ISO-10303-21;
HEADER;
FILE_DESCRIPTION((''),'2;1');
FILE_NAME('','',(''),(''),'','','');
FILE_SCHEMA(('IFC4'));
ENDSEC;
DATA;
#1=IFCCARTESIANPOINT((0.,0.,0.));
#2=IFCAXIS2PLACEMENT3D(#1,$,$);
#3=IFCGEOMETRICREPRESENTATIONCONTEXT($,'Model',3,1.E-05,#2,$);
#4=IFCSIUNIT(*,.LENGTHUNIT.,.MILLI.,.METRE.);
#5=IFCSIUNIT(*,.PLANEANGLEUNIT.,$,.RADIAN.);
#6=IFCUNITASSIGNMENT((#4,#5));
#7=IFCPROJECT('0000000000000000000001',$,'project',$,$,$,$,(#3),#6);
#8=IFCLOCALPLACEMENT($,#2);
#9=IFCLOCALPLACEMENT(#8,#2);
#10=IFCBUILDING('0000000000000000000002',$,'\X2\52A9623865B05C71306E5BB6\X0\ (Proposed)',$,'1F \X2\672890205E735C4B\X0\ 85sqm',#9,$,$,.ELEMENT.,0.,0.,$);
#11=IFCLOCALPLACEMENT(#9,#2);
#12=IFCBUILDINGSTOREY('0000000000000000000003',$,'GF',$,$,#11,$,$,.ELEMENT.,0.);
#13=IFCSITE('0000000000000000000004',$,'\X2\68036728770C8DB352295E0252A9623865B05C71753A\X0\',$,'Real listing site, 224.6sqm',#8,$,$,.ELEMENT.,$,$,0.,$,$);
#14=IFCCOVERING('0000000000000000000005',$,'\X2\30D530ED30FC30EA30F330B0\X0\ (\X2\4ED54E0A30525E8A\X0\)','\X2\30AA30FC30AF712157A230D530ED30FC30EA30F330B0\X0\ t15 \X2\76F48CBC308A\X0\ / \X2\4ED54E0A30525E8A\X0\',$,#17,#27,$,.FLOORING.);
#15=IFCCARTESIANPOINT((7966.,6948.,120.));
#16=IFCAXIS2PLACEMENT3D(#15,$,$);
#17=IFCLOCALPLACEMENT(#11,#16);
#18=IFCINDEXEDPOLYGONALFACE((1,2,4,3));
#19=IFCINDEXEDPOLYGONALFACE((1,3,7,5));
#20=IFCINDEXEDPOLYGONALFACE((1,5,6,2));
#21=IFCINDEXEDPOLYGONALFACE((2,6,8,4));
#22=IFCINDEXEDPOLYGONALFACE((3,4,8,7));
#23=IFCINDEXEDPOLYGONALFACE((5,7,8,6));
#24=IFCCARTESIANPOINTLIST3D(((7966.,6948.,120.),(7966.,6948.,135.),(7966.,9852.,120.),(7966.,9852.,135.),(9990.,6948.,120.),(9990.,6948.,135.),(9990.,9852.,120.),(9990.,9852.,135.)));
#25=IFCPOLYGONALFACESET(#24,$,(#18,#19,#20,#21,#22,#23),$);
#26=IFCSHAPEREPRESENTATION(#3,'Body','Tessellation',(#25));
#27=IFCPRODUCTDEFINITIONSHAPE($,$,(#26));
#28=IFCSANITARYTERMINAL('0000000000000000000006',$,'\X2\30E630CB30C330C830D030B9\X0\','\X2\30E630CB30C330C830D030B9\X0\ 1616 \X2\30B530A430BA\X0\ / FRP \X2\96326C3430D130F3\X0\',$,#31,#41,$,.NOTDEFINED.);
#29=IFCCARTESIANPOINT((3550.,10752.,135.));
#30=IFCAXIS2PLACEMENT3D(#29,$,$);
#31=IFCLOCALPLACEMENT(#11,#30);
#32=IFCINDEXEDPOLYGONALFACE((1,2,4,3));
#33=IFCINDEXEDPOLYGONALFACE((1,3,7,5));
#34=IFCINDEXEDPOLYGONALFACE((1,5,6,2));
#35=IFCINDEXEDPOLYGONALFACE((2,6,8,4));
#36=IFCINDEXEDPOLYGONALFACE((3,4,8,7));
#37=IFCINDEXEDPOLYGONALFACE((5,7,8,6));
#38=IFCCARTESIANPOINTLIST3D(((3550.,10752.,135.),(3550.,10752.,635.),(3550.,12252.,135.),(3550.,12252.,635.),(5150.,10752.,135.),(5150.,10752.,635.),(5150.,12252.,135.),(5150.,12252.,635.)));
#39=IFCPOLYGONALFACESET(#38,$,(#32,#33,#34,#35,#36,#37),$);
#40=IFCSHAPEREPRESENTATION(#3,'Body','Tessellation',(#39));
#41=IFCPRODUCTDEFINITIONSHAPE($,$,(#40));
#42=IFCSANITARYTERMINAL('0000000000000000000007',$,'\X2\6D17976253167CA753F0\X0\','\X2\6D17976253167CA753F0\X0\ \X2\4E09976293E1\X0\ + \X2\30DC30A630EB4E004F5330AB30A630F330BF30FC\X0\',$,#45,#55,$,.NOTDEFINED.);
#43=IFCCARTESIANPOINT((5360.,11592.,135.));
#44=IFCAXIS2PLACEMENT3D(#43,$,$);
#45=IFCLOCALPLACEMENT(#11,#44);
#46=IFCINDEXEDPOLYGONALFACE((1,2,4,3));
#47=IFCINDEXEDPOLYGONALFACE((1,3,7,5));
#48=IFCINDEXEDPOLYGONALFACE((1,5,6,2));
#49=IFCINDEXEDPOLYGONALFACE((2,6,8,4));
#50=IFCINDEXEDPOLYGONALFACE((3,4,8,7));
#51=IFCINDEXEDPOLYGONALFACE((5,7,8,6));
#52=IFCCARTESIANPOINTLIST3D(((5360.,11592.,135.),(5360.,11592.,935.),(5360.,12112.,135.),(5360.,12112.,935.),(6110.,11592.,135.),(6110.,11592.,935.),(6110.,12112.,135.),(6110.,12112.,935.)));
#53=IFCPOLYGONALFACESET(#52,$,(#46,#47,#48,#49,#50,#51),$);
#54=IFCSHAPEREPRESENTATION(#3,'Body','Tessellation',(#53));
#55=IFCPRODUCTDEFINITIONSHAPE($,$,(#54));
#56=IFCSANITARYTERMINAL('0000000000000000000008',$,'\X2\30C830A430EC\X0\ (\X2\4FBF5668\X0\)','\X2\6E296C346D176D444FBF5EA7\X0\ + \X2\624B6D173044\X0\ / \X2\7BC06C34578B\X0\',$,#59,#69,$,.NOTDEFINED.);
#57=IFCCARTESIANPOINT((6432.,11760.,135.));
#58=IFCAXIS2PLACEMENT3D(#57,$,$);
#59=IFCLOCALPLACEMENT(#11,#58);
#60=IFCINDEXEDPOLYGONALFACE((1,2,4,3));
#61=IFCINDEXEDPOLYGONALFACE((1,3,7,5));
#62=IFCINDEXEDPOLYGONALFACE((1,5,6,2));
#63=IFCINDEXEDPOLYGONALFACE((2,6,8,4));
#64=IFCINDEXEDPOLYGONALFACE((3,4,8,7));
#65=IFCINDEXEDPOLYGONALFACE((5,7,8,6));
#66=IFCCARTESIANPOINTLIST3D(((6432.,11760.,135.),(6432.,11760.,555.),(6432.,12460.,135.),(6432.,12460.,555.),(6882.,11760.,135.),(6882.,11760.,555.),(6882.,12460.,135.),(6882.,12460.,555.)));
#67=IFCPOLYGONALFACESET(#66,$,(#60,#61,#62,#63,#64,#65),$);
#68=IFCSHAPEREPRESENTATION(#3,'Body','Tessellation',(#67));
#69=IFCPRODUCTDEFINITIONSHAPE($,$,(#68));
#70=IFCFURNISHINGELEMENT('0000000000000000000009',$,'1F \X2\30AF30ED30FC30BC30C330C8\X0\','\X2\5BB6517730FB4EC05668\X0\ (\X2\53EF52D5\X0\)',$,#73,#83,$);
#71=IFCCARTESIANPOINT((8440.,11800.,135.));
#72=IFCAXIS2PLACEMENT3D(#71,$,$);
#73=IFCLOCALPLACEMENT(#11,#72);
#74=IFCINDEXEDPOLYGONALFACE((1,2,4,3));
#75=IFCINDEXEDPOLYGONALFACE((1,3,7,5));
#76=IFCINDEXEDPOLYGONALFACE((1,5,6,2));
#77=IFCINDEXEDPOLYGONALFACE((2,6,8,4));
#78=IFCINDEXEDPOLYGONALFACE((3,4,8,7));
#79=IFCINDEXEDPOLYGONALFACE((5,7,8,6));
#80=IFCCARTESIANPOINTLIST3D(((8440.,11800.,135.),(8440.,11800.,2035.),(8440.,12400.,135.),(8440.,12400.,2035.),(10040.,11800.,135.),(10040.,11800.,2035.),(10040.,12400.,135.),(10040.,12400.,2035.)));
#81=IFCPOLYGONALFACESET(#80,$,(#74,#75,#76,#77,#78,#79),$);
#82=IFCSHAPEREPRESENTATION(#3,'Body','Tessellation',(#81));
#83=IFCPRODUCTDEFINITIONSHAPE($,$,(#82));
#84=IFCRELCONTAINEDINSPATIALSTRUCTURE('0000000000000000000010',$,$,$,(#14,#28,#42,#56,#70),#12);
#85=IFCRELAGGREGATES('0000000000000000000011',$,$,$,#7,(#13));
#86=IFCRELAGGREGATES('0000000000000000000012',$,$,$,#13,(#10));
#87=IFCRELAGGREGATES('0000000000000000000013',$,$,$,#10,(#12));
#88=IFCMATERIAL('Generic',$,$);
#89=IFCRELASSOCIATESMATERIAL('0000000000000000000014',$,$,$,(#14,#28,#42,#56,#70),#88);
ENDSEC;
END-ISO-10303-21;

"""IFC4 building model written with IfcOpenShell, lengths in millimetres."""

from ifc_helpers import new_model, si_unit, frame, frame_2d, origin, place, context, project, spatial, rectangle, extrude, material, element, save


model = new_model("IFC4")

# Units and contexts
model_context = context("Model", 3, precision=1e-05, world=origin())
ifc_project = project(units=[si_unit("LENGTHUNIT", "METRE", prefix="MILLI"), si_unit("PLANEANGLEUNIT", "RADIAN")], contexts=[model_context])

# Site, building, storey
site_placement = place(None, origin())
site = spatial("IfcSite", under=ifc_project, at=site_placement, Name="栃木県足利市助戸新山町", ObjectType="Real listing site, 224.6sqm", CompositionType="ELEMENT", RefElevation=0.0)
building_placement = place(site_placement, origin())
building = spatial("IfcBuilding", under=site, at=building_placement, Name="助戸新山の家 (Proposed)", ObjectType="1F 木造平屋 85sqm", CompositionType="ELEMENT", ElevationOfRefHeight=0.0, ElevationOfTerrain=0.0)
storey_placement = place(building_placement, origin())
storey = spatial("IfcBuildingStorey", under=building, at=storey_placement, Name="GF", CompositionType="ELEMENT", Elevation=0.0)

# Covering
ifc_material_1 = material(Name="Generic")
covering_1_placement = place(storey_placement, frame((7966.0, 6948.0, 120.0)))
element("IfcCovering", 1, at=covering_1_placement, inside=storey, material=ifc_material_1, Name="フローリング (仕上げ床)", Description="オーク無垢フローリング t15 直貼り / 仕上げ床", PredefinedType="FLOORING", context=model_context, shape_type="SweptSolid", body=[
    extrude(rectangle(XDim=2024.0, YDim=2904.0, at=frame_2d((1012.0, 1452.0))), frame((7966.0, 6948.0, 120.0)), (0.0, 0.0, 1.0), 15.0),
])

# Sanitary terminals
sanitary_terminal_1_placement = place(storey_placement, frame((3550.0, 10752.0, 135.0)))
element("IfcSanitaryTerminal", 2, at=sanitary_terminal_1_placement, inside=storey, material=ifc_material_1, Name="ユニットバス", Description="ユニットバス 1616 サイズ / FRP 防水パン", PredefinedType="NOTDEFINED", context=model_context, shape_type="SweptSolid", body=[
    extrude(rectangle(XDim=1600.0, YDim=1500.0, at=frame_2d((800.0, 750.0))), frame((3550.0, 10752.0, 135.0)), (0.0, 0.0, 1.0), 500.0),
])
sanitary_terminal_2_placement = place(storey_placement, frame((5360.0, 11592.0, 135.0)))
element("IfcSanitaryTerminal", 3, at=sanitary_terminal_2_placement, inside=storey, material=ifc_material_1, Name="洗面化粧台", Description="洗面化粧台 三面鏡 + ボウル一体カウンター", PredefinedType="NOTDEFINED", context=model_context, shape_type="SweptSolid", body=[
    extrude(rectangle(XDim=750.0, YDim=520.0, at=frame_2d((375.0, 260.0))), frame((5360.0, 11592.0, 135.0)), (0.0, 0.0, 1.0), 800.0),
])
sanitary_terminal_3_placement = place(storey_placement, frame((6432.0, 11760.0, 135.0)))
element("IfcSanitaryTerminal", 4, at=sanitary_terminal_3_placement, inside=storey, material=ifc_material_1, Name="トイレ (便器)", Description="温水洗浄便座 + 手洗い / 節水型", PredefinedType="NOTDEFINED", context=model_context, shape_type="SweptSolid", body=[
    extrude(rectangle(XDim=450.0, YDim=700.0, at=frame_2d((225.0, 350.0))), frame((6432.0, 11760.0, 135.0)), (0.0, 0.0, 1.0), 420.0),
])

# Furnishing element
furnishing_placement = place(storey_placement, frame((8440.0, 11800.0, 135.0)))
element("IfcFurnishingElement", 5, at=furnishing_placement, inside=storey, material=ifc_material_1, Name="1F クローゼット", Description="家具・什器 (可動)", context=model_context, shape_type="SweptSolid", body=[
    extrude(rectangle(XDim=1600.0, YDim=600.0, at=frame_2d((800.0, 300.0))), frame((8440.0, 11800.0, 135.0)), (0.0, 0.0, 1.0), 1900.0),
])

save(model, "model.ifc")
